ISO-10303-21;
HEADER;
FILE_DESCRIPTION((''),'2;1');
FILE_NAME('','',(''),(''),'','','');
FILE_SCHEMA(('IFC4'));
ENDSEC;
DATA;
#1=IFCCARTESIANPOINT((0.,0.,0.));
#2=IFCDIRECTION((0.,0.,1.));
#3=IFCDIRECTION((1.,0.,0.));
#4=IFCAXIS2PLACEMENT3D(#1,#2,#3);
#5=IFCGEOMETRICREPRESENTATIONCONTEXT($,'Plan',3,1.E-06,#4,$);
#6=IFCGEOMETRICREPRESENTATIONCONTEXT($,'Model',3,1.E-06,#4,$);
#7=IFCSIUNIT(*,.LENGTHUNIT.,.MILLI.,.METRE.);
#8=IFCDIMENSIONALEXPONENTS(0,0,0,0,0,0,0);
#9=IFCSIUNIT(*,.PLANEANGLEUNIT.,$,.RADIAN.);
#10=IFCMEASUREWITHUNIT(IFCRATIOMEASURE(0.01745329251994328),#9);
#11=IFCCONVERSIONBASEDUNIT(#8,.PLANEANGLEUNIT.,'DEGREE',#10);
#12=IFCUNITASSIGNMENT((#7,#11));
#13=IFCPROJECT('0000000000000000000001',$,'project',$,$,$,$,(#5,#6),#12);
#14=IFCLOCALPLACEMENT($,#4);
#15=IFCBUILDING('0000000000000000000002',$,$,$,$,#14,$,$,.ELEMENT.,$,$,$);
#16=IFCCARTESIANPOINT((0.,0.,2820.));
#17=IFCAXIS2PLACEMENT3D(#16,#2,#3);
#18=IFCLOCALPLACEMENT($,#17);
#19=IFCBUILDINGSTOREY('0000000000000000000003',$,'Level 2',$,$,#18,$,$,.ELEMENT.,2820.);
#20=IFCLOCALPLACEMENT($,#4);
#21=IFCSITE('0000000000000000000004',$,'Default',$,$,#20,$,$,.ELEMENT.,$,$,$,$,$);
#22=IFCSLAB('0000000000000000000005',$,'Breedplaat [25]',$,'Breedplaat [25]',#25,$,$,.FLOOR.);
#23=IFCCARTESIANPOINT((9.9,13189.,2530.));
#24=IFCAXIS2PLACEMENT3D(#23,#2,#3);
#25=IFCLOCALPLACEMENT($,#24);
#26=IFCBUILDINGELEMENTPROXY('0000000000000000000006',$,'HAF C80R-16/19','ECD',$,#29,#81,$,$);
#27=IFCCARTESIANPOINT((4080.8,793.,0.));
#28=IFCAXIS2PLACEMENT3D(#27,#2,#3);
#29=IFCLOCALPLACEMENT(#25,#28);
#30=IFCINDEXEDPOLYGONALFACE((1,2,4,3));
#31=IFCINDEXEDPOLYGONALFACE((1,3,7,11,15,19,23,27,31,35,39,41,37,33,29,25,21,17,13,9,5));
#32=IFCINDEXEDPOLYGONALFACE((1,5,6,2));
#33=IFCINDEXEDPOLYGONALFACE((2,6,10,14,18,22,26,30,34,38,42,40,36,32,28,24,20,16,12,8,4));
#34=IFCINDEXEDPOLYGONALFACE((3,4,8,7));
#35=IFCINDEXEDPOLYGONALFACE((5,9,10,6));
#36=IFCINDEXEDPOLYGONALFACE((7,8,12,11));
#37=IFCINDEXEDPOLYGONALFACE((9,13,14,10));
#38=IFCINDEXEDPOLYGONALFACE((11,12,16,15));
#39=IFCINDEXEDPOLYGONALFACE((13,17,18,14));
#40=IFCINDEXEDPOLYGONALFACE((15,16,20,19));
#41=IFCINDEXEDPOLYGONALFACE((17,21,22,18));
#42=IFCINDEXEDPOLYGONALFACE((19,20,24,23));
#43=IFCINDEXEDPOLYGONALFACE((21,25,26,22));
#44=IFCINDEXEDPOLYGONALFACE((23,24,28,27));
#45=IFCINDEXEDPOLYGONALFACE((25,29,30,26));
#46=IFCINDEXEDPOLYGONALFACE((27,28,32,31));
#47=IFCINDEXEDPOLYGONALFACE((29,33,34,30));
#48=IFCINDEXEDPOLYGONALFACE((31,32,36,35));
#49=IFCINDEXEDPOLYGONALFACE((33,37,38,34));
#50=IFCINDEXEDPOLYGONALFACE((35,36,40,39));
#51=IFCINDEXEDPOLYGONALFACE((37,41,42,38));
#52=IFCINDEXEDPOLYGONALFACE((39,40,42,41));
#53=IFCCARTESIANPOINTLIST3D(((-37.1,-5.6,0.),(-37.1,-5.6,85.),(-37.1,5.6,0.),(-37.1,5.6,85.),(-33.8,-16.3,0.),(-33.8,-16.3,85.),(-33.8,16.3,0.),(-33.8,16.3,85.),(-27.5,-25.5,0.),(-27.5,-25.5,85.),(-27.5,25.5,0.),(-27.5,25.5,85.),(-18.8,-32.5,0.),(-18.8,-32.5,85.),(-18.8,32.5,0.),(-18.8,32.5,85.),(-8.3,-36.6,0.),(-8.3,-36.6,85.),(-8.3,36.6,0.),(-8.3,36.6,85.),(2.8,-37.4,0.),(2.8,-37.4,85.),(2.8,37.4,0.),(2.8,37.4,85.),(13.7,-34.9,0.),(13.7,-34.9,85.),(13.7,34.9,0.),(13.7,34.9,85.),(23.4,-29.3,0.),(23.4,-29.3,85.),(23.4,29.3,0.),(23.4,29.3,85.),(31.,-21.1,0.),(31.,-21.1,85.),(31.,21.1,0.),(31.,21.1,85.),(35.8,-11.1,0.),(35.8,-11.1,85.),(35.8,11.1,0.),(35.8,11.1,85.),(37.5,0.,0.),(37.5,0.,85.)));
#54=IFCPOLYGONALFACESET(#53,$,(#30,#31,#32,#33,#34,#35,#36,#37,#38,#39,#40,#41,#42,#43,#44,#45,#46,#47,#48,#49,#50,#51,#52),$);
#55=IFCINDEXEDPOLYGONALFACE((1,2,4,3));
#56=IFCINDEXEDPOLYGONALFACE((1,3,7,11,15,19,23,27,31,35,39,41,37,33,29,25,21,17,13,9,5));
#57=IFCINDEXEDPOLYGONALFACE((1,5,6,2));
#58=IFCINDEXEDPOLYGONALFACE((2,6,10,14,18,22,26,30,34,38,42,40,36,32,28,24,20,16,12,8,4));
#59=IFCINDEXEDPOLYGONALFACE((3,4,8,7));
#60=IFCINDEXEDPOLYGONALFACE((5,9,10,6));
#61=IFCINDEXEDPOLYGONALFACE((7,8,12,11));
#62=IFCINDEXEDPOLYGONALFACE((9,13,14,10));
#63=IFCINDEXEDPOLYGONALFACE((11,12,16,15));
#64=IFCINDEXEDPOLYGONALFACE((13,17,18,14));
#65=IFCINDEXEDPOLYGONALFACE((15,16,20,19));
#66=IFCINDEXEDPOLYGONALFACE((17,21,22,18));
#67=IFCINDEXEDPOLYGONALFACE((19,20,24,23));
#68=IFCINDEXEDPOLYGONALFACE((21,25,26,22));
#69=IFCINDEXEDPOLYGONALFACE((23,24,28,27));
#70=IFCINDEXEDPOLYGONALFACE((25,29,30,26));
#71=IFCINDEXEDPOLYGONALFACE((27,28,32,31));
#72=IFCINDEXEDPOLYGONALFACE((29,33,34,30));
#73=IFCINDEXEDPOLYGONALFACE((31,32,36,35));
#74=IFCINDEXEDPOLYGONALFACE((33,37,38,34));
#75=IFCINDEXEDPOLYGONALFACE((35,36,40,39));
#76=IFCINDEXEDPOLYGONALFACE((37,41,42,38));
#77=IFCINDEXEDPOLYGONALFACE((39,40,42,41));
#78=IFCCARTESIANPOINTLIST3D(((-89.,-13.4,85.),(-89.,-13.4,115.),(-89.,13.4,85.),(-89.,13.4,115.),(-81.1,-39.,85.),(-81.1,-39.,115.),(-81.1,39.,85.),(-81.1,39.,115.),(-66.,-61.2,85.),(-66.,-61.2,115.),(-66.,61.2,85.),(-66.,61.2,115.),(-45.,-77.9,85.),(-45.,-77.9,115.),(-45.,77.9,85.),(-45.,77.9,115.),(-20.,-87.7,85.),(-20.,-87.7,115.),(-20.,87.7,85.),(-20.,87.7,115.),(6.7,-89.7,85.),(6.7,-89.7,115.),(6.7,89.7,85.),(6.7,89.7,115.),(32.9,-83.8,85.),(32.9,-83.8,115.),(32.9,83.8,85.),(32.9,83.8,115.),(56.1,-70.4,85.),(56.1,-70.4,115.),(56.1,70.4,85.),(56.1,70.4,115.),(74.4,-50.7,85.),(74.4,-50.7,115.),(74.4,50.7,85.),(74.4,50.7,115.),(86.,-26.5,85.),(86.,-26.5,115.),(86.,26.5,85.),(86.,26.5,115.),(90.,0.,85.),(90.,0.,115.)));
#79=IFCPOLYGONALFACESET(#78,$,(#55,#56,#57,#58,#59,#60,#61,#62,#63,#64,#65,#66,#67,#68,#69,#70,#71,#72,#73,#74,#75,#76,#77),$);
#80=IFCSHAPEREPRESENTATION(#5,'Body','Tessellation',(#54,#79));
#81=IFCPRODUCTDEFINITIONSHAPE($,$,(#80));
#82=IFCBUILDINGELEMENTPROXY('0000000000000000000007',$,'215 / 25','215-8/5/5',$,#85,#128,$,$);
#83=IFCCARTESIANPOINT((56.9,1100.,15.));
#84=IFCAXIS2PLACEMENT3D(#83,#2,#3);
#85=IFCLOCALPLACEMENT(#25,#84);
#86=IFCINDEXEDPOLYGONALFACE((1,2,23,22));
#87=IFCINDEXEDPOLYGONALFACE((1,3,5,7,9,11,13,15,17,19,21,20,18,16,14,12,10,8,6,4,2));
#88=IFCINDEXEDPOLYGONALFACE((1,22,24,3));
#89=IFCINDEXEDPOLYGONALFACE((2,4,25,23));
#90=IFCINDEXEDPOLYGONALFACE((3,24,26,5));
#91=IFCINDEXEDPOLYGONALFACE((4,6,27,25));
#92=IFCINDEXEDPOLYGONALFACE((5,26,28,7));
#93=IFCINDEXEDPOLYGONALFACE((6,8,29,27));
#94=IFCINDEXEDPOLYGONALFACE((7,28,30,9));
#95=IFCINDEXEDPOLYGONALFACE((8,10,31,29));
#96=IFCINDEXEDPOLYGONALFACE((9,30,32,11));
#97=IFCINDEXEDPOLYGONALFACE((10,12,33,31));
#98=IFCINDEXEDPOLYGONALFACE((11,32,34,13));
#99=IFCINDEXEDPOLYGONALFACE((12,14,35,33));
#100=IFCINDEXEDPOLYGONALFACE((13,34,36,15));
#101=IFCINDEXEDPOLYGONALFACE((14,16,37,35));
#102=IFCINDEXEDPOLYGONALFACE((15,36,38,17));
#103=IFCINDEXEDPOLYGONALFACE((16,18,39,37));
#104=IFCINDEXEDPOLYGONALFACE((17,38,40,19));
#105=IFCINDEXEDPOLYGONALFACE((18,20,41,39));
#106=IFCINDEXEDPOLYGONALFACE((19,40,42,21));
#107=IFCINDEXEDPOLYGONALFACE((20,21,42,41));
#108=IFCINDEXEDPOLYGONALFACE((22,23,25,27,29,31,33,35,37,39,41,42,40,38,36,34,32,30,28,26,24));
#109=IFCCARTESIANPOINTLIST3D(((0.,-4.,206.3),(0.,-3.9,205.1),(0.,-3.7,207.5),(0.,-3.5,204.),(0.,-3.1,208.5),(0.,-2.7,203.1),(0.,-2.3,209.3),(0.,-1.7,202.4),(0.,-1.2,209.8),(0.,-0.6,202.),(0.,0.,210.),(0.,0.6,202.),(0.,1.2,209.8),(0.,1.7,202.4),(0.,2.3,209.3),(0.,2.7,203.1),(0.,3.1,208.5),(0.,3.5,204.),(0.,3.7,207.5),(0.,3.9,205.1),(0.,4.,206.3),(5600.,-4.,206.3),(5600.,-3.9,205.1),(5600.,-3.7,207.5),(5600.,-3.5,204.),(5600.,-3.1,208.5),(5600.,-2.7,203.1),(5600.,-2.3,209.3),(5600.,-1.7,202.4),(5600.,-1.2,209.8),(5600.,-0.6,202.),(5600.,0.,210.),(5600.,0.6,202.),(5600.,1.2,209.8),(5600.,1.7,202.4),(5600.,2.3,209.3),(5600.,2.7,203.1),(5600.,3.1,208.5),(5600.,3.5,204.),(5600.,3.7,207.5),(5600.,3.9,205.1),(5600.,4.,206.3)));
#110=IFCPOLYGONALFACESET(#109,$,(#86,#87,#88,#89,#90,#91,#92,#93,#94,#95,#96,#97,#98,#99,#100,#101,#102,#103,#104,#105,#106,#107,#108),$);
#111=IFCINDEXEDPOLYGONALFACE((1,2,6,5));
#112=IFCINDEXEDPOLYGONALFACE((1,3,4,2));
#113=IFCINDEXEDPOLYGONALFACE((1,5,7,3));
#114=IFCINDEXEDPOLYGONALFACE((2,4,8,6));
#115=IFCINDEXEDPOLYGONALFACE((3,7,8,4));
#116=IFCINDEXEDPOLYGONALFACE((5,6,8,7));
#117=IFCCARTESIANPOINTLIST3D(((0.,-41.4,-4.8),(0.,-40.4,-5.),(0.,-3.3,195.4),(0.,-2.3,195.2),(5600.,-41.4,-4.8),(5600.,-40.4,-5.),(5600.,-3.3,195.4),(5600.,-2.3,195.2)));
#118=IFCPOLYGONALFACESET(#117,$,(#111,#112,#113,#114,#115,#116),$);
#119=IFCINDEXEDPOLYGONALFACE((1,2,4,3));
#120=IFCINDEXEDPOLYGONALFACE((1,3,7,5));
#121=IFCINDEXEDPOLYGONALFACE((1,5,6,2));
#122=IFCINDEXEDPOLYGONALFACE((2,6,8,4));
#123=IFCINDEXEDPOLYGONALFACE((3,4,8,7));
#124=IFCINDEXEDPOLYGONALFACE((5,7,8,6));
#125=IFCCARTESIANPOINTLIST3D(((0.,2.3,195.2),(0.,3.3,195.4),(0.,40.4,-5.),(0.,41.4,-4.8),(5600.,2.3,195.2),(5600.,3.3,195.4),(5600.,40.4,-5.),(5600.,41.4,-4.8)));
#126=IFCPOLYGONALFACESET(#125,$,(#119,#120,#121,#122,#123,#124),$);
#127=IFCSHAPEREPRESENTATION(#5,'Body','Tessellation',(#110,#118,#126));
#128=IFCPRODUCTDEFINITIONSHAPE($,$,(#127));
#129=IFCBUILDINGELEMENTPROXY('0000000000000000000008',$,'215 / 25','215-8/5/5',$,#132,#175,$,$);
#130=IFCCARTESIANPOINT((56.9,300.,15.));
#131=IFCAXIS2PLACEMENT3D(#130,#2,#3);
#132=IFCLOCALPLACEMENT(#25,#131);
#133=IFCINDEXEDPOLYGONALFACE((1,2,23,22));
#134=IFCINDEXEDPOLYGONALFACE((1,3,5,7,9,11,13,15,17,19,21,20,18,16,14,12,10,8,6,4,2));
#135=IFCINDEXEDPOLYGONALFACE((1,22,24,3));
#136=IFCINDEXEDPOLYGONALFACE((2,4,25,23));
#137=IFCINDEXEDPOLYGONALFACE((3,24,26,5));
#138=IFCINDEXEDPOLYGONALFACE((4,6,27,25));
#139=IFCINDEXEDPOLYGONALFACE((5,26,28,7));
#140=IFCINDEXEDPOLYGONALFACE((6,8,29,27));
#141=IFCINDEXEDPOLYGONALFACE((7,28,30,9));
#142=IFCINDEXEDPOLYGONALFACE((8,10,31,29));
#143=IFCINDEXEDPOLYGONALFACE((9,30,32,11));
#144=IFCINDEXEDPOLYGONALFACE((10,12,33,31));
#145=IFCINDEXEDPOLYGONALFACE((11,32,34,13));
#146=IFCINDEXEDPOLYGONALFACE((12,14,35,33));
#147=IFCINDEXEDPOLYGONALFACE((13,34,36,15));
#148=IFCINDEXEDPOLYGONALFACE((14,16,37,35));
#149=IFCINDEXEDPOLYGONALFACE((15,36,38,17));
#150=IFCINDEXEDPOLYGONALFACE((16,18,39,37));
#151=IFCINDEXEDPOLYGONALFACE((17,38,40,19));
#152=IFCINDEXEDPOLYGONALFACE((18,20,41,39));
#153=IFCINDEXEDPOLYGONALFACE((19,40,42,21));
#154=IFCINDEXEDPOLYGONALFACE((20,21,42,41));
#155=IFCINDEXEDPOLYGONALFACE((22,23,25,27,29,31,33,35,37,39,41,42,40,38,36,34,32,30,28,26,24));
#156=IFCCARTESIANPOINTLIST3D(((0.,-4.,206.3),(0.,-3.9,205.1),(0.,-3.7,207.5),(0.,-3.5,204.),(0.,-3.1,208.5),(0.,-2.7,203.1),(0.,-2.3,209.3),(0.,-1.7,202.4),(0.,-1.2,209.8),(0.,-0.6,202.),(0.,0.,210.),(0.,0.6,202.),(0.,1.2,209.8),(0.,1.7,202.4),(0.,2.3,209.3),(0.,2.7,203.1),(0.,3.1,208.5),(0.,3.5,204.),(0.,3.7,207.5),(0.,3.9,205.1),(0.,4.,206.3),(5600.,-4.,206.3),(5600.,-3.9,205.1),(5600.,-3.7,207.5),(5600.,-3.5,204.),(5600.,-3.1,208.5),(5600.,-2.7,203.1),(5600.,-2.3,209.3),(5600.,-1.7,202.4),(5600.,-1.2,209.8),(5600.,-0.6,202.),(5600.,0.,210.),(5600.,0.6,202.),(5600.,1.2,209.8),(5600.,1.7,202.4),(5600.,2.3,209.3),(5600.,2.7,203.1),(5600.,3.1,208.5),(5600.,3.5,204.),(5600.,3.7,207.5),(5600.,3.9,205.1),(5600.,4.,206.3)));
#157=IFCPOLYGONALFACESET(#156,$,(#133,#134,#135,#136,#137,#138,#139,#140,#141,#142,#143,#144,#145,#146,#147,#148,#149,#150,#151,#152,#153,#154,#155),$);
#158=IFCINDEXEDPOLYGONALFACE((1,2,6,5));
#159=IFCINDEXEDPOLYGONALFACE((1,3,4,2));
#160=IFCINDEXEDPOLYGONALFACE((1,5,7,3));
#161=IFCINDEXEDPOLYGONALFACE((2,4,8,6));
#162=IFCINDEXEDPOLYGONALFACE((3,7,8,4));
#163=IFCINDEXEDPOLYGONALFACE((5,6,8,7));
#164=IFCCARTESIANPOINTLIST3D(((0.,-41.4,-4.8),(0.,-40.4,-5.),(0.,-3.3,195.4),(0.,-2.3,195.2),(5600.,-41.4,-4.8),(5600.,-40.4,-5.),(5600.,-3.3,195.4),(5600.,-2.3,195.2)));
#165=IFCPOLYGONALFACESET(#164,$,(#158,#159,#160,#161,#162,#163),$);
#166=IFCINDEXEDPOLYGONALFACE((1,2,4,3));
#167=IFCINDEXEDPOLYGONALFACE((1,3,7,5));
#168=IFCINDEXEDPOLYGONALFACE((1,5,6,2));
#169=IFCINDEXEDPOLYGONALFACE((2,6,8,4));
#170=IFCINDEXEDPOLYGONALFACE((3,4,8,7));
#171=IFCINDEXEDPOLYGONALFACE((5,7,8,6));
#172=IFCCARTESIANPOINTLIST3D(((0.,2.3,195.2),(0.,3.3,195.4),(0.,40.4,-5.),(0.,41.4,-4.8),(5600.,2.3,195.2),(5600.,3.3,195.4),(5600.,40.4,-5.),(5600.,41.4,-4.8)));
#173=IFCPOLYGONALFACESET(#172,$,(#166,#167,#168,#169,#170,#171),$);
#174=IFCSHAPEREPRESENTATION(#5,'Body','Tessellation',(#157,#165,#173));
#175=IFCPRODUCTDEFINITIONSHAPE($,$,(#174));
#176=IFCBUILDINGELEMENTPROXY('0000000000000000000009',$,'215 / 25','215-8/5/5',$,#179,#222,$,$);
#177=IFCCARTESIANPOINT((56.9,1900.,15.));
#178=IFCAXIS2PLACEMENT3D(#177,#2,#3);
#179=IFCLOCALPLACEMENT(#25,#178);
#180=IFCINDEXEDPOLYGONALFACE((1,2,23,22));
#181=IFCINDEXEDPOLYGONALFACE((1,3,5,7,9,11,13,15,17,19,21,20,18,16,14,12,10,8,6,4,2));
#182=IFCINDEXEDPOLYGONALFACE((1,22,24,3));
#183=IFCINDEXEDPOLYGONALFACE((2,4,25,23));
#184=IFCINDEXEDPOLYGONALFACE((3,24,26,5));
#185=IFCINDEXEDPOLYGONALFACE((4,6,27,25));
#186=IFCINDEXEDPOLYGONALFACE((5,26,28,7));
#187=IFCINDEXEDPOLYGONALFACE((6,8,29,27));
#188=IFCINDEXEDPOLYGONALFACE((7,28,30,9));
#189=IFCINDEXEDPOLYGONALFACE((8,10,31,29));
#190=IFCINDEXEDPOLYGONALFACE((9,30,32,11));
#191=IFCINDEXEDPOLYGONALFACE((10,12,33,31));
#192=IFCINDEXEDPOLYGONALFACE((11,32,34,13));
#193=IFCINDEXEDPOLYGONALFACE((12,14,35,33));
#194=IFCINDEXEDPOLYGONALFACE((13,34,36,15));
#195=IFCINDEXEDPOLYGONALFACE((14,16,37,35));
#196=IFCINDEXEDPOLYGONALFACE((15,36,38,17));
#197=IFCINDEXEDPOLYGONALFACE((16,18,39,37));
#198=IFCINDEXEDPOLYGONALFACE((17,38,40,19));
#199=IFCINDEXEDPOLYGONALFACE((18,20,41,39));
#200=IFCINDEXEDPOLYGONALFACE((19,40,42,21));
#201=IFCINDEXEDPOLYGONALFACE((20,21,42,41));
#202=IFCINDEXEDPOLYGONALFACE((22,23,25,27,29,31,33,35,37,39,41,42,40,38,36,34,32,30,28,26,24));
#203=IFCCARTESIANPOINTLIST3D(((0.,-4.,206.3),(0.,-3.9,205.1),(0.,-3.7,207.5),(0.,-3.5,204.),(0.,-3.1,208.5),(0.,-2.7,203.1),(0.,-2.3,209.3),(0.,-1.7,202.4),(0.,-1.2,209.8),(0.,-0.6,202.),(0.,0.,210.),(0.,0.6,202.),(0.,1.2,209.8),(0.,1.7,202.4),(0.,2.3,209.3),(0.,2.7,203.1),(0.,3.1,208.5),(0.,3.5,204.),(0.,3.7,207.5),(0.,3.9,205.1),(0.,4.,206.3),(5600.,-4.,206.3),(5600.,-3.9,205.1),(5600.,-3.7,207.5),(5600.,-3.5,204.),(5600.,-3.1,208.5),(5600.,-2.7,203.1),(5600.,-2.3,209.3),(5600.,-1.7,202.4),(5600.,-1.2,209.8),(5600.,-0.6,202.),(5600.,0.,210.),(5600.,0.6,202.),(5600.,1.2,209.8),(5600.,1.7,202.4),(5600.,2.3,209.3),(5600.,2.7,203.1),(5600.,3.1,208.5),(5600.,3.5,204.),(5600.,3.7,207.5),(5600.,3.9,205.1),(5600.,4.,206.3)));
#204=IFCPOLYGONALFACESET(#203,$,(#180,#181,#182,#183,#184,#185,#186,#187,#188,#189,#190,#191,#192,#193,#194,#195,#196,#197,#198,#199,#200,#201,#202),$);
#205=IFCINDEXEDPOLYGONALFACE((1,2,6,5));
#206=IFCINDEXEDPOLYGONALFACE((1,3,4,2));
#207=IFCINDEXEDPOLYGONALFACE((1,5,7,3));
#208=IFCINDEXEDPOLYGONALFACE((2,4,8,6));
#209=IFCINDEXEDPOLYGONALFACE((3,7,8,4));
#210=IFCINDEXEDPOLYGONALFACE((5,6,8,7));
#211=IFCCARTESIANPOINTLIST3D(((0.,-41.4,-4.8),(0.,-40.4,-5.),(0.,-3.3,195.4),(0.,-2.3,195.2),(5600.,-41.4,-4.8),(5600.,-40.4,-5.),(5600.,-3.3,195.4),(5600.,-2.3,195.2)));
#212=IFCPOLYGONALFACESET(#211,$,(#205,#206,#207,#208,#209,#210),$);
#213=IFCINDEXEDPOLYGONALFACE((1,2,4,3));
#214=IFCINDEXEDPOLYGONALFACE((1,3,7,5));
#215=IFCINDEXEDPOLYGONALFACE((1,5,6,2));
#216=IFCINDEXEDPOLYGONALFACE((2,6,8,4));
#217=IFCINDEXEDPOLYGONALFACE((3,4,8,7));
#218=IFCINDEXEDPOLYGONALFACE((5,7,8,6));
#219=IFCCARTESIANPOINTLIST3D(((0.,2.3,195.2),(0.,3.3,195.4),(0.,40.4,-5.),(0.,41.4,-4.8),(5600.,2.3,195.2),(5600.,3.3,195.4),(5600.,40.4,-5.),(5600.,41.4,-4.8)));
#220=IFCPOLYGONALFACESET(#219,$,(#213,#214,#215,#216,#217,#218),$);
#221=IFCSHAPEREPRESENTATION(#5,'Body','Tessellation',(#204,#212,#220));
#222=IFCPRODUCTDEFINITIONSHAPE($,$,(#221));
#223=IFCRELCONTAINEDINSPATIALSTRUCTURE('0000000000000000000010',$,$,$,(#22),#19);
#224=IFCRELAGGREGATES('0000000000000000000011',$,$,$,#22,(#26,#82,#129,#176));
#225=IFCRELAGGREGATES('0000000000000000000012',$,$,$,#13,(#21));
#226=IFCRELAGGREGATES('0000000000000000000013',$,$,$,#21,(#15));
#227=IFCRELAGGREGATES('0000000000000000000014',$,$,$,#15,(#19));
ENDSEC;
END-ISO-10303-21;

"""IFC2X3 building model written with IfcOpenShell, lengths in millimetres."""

from ifc_helpers import new_model, entity, si_unit, converted_unit, frame, origin_with_axes, origin_2d_with_axis, place, context, project, spatial, rectangle, circle, extrude, element, aggregate, save


model = new_model("IFC2X3")

# Units and contexts
plan_context = context("Plan", 3, precision=1e-06, world=origin_with_axes())
model_context = context("Model", 3, precision=1e-06, world=origin_with_axes())
ifc_project = project(units=[si_unit("LENGTHUNIT", "METRE", prefix="MILLI"), converted_unit("PLANEANGLEUNIT", "DEGREE", entity("IfcRatioMeasure", 0.01745329251994328), si_unit("PLANEANGLEUNIT", "RADIAN"), dimensions=[0, 0, 0, 0, 0, 0, 0])], contexts=[plan_context, model_context])

# Site, building, storey
site_placement = place(None, origin_with_axes())
site = spatial("IfcSite", under=ifc_project, at=site_placement, Name="Default", CompositionType="ELEMENT")
building_placement = place(None, origin_with_axes())
building = spatial("IfcBuilding", under=site, at=building_placement, CompositionType="ELEMENT")
storey_placement = place(None, frame((0.0, 0.0, 2820.0), z_axis=(0.0, 0.0, 1.0), x_axis=(1.0, 0.0, 0.0)))
storey = spatial("IfcBuildingStorey", under=building, at=storey_placement, Name="Level 2", CompositionType="ELEMENT", Elevation=2820.0)

# Slab, building element proxies
slab_1_placement = place(None, frame((9.9, 13189.0, 2530.0), z_axis=(0.0, 0.0, 1.0), x_axis=(1.0, 0.0, 0.0)))
slab_1 = element("IfcSlab", 1, at=slab_1_placement, inside=storey, Name="Breedplaat [25]", ObjectType="Breedplaat [25]", PredefinedType="FLOOR")
proxy_1_placement = place(slab_1_placement, frame((4080.8, 793.0, 0.0), z_axis=(0.0, 0.0, 1.0), x_axis=(1.0, 0.0, 0.0)))
proxy_1 = element("IfcBuildingElementProxy", 2, at=proxy_1_placement, Name="HAF C80R-16/19", Description="ECD", context=plan_context, shape_type="SweptSolid", body=[
    extrude(circle(Radius=37.5, at=origin_2d_with_axis()), origin_with_axes(), (0.0, 0.0, 1.0), 85.0),
    extrude(circle(Radius=90.0, at=origin_2d_with_axis()), frame((0.0, 0.0, 85.0), z_axis=(0.0, 0.0, 1.0), x_axis=(1.0, 0.0, 0.0)), (0.0, 0.0, 1.0), 30.0),
])
proxy_2_placement = place(slab_1_placement, frame((56.9, 1100.0, 15.0), z_axis=(0.0, 0.0, 1.0), x_axis=(1.0, 0.0, 0.0)))
proxy_2 = element("IfcBuildingElementProxy", 3, at=proxy_2_placement, Name="215 / 25", Description="215-8/5/5", context=plan_context, shape_type="SweptSolid", body=[
    extrude(circle(Radius=4.0, at=origin_2d_with_axis()), frame((0.0, 0.0, 206.0), z_axis=(1.0, 0.0, 0.0), x_axis=(0.0, 0.0, 1.0)), (0.0, 0.0, 1.0), 5600.0),
    extrude(rectangle(XDim=203.8, YDim=1.0, at=origin_2d_with_axis()), frame((0.0, -21.9, 95.2), z_axis=(1.0, 0.0, 0.0), x_axis=(0.0, 0.187112, 0.982339)), (0.0, 0.0, 1.0), 5600.0),
    extrude(rectangle(XDim=203.8, YDim=1.0, at=origin_2d_with_axis()), frame((0.0, 21.9, 95.2), z_axis=(1.0, 0.0, 0.0), x_axis=(0.0, -0.187112, 0.982339)), (0.0, 0.0, 1.0), 5600.0),
])
proxy_3_placement = place(slab_1_placement, frame((56.9, 300.0, 15.0), z_axis=(0.0, 0.0, 1.0), x_axis=(1.0, 0.0, 0.0)))
proxy_3 = element("IfcBuildingElementProxy", 4, at=proxy_3_placement, Name="215 / 25", Description="215-8/5/5", context=plan_context, shape_type="SweptSolid", body=[
    extrude(circle(Radius=4.0, at=origin_2d_with_axis()), frame((0.0, 0.0, 206.0), z_axis=(1.0, 0.0, 0.0), x_axis=(0.0, 0.0, 1.0)), (0.0, 0.0, 1.0), 5600.0),
    extrude(rectangle(XDim=203.8, YDim=1.0, at=origin_2d_with_axis()), frame((0.0, -21.9, 95.2), z_axis=(1.0, 0.0, 0.0), x_axis=(0.0, 0.187112, 0.982339)), (0.0, 0.0, 1.0), 5600.0),
    extrude(rectangle(XDim=203.8, YDim=1.0, at=origin_2d_with_axis()), frame((0.0, 21.9, 95.2), z_axis=(1.0, 0.0, 0.0), x_axis=(0.0, -0.187112, 0.982339)), (0.0, 0.0, 1.0), 5600.0),
])
proxy_4_placement = place(slab_1_placement, frame((56.9, 1900.0, 15.0), z_axis=(0.0, 0.0, 1.0), x_axis=(1.0, 0.0, 0.0)))
proxy_4 = element("IfcBuildingElementProxy", 5, at=proxy_4_placement, Name="215 / 25", Description="215-8/5/5", context=plan_context, shape_type="SweptSolid", body=[
    extrude(circle(Radius=4.0, at=origin_2d_with_axis()), frame((0.0, 0.0, 206.0), z_axis=(1.0, 0.0, 0.0), x_axis=(0.0, 0.0, 1.0)), (0.0, 0.0, 1.0), 5600.0),
    extrude(rectangle(XDim=203.8, YDim=1.0, at=origin_2d_with_axis()), frame((0.0, -21.9, 95.2), z_axis=(1.0, 0.0, 0.0), x_axis=(0.0, 0.187112, 0.982339)), (0.0, 0.0, 1.0), 5600.0),
    extrude(rectangle(XDim=203.8, YDim=1.0, at=origin_2d_with_axis()), frame((0.0, 21.9, 95.2), z_axis=(1.0, 0.0, 0.0), x_axis=(0.0, -0.187112, 0.982339)), (0.0, 0.0, 1.0), 5600.0),
])
aggregate(slab_1, [proxy_1, proxy_2, proxy_3, proxy_4])

save(model, "model.ifc")
